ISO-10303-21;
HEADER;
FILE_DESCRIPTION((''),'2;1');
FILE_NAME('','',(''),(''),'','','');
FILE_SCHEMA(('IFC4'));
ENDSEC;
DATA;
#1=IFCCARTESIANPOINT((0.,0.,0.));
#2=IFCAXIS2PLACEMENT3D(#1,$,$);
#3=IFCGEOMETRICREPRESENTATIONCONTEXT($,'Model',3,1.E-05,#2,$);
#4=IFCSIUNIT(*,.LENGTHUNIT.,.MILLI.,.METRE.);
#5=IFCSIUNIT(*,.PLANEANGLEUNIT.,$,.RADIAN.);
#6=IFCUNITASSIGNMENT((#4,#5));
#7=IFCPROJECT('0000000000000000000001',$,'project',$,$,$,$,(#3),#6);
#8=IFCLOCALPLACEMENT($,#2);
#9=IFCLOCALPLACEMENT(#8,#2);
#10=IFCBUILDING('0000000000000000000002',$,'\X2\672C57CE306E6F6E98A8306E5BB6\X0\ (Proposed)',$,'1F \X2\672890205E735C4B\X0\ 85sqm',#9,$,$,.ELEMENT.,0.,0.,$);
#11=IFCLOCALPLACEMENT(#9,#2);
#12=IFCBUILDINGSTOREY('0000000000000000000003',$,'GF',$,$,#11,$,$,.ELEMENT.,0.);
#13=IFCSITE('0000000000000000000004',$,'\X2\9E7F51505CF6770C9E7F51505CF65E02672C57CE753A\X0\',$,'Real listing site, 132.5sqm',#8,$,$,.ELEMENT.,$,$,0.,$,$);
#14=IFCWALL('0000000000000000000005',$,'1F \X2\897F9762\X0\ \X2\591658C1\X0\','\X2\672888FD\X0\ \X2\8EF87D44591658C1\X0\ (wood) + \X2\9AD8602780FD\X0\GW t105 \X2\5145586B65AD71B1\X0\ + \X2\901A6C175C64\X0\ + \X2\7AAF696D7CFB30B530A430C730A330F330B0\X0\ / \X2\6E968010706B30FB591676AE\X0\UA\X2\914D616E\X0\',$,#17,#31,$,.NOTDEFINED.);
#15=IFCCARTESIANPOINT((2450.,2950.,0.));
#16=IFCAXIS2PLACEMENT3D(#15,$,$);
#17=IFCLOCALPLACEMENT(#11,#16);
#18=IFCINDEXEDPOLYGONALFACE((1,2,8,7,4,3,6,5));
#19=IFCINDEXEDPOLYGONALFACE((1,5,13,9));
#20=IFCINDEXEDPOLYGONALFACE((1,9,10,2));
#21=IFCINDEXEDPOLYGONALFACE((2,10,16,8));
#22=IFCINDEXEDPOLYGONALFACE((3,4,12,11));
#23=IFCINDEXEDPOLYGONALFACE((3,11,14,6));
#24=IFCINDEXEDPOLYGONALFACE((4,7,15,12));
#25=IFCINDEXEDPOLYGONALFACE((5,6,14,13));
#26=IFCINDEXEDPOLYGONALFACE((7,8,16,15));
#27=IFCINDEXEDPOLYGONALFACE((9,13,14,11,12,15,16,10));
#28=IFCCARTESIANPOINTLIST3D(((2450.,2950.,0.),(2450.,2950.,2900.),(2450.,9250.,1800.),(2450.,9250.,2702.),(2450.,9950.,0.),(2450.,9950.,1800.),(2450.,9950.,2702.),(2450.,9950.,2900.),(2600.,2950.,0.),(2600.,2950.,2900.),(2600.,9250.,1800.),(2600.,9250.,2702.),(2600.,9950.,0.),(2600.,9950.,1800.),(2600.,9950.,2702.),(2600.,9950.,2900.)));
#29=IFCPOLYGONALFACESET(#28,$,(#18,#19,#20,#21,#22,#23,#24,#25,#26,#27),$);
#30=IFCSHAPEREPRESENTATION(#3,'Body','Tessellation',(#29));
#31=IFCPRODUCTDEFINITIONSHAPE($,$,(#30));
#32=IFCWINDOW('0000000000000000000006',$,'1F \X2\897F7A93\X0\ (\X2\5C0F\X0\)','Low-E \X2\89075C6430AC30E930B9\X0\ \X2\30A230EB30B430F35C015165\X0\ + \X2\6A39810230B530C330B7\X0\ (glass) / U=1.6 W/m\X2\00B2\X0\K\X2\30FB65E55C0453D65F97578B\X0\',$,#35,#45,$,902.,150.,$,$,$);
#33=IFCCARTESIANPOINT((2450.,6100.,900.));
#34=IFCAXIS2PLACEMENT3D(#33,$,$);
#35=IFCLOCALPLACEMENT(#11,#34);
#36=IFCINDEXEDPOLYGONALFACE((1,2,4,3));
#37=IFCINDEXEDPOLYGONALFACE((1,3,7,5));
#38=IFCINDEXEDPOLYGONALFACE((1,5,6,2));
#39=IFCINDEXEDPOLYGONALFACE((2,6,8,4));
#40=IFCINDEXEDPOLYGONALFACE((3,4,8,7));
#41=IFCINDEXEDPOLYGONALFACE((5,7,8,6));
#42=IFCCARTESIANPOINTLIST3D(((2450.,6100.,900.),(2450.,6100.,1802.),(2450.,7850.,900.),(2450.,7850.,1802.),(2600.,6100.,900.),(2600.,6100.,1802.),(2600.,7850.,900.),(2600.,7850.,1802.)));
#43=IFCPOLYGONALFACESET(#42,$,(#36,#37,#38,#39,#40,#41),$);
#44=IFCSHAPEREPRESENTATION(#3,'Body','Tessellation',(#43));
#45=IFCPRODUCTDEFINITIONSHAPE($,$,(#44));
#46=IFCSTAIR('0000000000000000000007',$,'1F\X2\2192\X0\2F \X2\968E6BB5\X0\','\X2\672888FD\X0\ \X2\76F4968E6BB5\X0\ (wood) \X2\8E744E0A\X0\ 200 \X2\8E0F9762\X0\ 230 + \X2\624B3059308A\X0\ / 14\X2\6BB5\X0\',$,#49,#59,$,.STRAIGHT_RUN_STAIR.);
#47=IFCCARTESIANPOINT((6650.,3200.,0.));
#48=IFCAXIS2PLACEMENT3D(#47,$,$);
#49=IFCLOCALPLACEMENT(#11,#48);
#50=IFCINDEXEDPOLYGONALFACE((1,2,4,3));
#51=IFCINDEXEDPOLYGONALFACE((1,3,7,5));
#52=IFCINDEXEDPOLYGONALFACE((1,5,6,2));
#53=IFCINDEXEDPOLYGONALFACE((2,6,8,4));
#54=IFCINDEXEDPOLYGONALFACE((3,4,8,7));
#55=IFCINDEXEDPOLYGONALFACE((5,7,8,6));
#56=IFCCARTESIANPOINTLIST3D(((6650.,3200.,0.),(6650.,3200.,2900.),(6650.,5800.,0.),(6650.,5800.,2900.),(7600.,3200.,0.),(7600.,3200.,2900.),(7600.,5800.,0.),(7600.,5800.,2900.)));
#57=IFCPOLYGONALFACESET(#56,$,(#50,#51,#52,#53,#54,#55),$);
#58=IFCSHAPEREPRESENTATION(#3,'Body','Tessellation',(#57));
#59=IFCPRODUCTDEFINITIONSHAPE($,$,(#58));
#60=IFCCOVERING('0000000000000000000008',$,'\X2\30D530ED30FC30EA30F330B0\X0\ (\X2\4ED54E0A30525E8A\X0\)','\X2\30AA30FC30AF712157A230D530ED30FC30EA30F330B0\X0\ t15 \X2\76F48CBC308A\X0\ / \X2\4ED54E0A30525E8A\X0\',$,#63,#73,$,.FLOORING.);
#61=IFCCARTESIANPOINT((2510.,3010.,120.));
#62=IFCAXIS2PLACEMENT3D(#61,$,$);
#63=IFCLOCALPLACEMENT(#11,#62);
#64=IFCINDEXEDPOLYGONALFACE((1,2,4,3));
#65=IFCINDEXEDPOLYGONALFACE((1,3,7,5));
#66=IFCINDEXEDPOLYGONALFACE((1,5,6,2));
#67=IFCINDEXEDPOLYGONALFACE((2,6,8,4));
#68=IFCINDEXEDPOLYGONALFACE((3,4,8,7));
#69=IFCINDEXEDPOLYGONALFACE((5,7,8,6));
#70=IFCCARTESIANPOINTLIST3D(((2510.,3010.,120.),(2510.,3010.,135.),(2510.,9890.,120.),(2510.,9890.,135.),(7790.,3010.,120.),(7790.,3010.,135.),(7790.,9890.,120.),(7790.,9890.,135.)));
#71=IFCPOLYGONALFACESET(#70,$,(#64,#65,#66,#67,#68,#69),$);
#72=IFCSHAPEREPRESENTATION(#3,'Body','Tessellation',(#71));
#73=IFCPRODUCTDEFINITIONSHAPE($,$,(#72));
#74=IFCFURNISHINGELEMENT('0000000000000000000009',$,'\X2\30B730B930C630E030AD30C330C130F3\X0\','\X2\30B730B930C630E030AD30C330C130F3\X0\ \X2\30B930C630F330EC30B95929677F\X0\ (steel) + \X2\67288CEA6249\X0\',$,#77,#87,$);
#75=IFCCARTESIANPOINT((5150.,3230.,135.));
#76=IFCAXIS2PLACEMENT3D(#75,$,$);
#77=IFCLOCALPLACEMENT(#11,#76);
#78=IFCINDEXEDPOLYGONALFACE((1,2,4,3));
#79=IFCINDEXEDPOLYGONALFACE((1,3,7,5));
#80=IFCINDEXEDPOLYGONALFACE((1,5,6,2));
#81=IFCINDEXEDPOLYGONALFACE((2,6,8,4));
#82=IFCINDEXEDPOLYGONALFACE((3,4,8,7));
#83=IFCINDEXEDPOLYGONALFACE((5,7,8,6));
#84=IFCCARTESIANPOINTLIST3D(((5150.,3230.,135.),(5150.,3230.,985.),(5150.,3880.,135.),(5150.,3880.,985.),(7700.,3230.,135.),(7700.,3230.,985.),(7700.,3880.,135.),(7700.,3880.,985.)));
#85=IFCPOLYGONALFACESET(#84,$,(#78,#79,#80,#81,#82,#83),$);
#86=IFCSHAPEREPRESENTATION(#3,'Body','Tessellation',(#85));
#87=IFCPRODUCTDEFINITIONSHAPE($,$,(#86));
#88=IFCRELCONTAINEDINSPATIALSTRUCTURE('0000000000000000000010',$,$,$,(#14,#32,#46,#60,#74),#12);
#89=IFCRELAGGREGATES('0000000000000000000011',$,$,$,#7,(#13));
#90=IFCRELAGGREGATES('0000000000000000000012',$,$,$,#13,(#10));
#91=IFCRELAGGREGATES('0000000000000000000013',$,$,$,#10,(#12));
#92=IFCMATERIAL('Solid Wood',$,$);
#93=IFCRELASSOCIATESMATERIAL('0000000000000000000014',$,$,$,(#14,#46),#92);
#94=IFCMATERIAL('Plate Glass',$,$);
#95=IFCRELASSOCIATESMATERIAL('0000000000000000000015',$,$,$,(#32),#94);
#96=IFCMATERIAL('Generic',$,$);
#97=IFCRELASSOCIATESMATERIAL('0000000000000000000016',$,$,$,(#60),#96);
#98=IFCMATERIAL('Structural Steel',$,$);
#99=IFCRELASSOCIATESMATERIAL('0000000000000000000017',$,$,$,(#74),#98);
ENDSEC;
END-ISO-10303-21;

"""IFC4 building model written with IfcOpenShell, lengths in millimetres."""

from ifc_helpers import new_model, si_unit, frame, frame_2d, origin, place, context, project, spatial, rectangle, extrude, material, element, fill, save


model = new_model("IFC4")

# Units and contexts
model_context = context("Model", 3, precision=1e-05, world=origin())
ifc_project = project(units=[si_unit("LENGTHUNIT", "METRE", prefix="MILLI"), si_unit("PLANEANGLEUNIT", "RADIAN")], contexts=[model_context])

# Site, building, storey
site_placement = place(None, origin())
site = spatial("IfcSite", under=ifc_project, at=site_placement, Name="鹿児島県鹿児島市本城町", ObjectType="Real listing site, 132.5sqm", CompositionType="ELEMENT", RefElevation=0.0)
building_placement = place(site_placement, origin())
building = spatial("IfcBuilding", under=site, at=building_placement, Name="本城の潮風の家 (Proposed)", ObjectType="1F 木造平屋 85sqm", CompositionType="ELEMENT", ElevationOfRefHeight=0.0, ElevationOfTerrain=0.0)
storey_placement = place(building_placement, origin())
storey = spatial("IfcBuildingStorey", under=building, at=storey_placement, Name="GF", CompositionType="ELEMENT", Elevation=0.0)

# Shared definitions
ifc_material_1 = material(Name="Solid Wood")
ifc_material_2 = material(Name="Generic")

# Shared definitions
ifc_material_3 = material(Name="Plate Glass")

# Wall, opening, window
wall_1_placement = place(storey_placement, frame((2450.0, 2950.0, 0.0)))
wall_1 = element("IfcWall", 1, at=wall_1_placement, inside=storey, material=ifc_material_1, Name="1F 西面 外壁", Description="木製 軸組外壁 (wood) + 高性能GW t105 充填断熱 + 通気層 + 窯業系サイディング / 準耐火・外皮UA配慮", PredefinedType="NOTDEFINED", context=model_context, shape_type="SweptSolid", body=[
    extrude(rectangle(XDim=150.0, YDim=7000.0, at=frame_2d((75.0, 3500.0))), frame((2450.0, 2950.0, 0.0)), (0.0, 0.0, 1.0), 2900.0),
])
opening_1_placement = place(storey_placement, frame((2450.0, 6100.0, 900.0)))
opening_1 = element("IfcOpeningElement", 2, at=opening_1_placement, cuts=wall_1, PredefinedType="NOTDEFINED", context=model_context, shape_type="SweptSolid", body=[
    extrude(rectangle(XDim=150.0, YDim=1750.0, at=frame_2d((75.0, 875.0))), frame((2450.0, 6100.0, 900.0)), (0.0, 0.0, 1.0), 902.0),
])
window_1_placement = place(storey_placement, frame((2450.0, 6100.0, 900.0)))
window_1 = element("IfcWindow", 3, at=window_1_placement, inside=storey, material=ifc_material_3, Name="1F 西窓 (小)", Description="Low-E 複層ガラス アルゴン封入 + 樹脂サッシ (glass) / U=1.6 W/m²K・日射取得型", OverallHeight=902.0, OverallWidth=150.0, context=model_context, shape_type="SweptSolid", body=[
    extrude(rectangle(XDim=150.0, YDim=1750.0, at=frame_2d((75.0, 875.0))), frame((2450.0, 6100.0, 900.0)), (0.0, 0.0, 1.0), 902.0),
])
fill(opening_1, window_1)

# Stair
stair_placement = place(storey_placement, frame((6650.0, 3200.0, 0.0)))
element("IfcStair", 4, at=stair_placement, inside=storey, material=ifc_material_1, Name="1F→2F 階段", Description="木製 直階段 (wood) 蹴上 200 踏面 230 + 手すり / 14段", PredefinedType="STRAIGHT_RUN_STAIR", context=model_context, shape_type="SweptSolid", body=[
    extrude(rectangle(XDim=950.0, YDim=2600.0, at=frame_2d((475.0, 1300.0))), frame((6650.0, 3200.0, 0.0)), (0.0, 0.0, 1.0), 2900.0),
])

# Covering
covering_placement = place(storey_placement, frame((2510.0, 3010.0, 120.0)))
element("IfcCovering", 5, at=covering_placement, inside=storey, material=ifc_material_2, Name="フローリング (仕上げ床)", Description="オーク無垢フローリング t15 直貼り / 仕上げ床", PredefinedType="FLOORING", context=model_context, shape_type="SweptSolid", body=[
    extrude(rectangle(XDim=5280.0, YDim=6880.0, at=frame_2d((2640.0, 3440.0))), frame((2510.0, 3010.0, 120.0)), (0.0, 0.0, 1.0), 15.0),
])

# Furnishing element
ifc_material_4 = material(Name="Structural Steel")
furnishing_placement = place(storey_placement, frame((5150.0, 3230.0, 135.0)))
element("IfcFurnishingElement", 6, at=furnishing_placement, inside=storey, material=ifc_material_4, Name="システムキッチン", Description="システムキッチン ステンレス天板 (steel) + 木質扉", context=model_context, shape_type="SweptSolid", body=[
    extrude(rectangle(XDim=2550.0, YDim=650.0, at=frame_2d((1275.0, 325.0))), frame((5150.0, 3230.0, 135.0)), (0.0, 0.0, 1.0), 850.0),
])

save(model, "model.ifc")
